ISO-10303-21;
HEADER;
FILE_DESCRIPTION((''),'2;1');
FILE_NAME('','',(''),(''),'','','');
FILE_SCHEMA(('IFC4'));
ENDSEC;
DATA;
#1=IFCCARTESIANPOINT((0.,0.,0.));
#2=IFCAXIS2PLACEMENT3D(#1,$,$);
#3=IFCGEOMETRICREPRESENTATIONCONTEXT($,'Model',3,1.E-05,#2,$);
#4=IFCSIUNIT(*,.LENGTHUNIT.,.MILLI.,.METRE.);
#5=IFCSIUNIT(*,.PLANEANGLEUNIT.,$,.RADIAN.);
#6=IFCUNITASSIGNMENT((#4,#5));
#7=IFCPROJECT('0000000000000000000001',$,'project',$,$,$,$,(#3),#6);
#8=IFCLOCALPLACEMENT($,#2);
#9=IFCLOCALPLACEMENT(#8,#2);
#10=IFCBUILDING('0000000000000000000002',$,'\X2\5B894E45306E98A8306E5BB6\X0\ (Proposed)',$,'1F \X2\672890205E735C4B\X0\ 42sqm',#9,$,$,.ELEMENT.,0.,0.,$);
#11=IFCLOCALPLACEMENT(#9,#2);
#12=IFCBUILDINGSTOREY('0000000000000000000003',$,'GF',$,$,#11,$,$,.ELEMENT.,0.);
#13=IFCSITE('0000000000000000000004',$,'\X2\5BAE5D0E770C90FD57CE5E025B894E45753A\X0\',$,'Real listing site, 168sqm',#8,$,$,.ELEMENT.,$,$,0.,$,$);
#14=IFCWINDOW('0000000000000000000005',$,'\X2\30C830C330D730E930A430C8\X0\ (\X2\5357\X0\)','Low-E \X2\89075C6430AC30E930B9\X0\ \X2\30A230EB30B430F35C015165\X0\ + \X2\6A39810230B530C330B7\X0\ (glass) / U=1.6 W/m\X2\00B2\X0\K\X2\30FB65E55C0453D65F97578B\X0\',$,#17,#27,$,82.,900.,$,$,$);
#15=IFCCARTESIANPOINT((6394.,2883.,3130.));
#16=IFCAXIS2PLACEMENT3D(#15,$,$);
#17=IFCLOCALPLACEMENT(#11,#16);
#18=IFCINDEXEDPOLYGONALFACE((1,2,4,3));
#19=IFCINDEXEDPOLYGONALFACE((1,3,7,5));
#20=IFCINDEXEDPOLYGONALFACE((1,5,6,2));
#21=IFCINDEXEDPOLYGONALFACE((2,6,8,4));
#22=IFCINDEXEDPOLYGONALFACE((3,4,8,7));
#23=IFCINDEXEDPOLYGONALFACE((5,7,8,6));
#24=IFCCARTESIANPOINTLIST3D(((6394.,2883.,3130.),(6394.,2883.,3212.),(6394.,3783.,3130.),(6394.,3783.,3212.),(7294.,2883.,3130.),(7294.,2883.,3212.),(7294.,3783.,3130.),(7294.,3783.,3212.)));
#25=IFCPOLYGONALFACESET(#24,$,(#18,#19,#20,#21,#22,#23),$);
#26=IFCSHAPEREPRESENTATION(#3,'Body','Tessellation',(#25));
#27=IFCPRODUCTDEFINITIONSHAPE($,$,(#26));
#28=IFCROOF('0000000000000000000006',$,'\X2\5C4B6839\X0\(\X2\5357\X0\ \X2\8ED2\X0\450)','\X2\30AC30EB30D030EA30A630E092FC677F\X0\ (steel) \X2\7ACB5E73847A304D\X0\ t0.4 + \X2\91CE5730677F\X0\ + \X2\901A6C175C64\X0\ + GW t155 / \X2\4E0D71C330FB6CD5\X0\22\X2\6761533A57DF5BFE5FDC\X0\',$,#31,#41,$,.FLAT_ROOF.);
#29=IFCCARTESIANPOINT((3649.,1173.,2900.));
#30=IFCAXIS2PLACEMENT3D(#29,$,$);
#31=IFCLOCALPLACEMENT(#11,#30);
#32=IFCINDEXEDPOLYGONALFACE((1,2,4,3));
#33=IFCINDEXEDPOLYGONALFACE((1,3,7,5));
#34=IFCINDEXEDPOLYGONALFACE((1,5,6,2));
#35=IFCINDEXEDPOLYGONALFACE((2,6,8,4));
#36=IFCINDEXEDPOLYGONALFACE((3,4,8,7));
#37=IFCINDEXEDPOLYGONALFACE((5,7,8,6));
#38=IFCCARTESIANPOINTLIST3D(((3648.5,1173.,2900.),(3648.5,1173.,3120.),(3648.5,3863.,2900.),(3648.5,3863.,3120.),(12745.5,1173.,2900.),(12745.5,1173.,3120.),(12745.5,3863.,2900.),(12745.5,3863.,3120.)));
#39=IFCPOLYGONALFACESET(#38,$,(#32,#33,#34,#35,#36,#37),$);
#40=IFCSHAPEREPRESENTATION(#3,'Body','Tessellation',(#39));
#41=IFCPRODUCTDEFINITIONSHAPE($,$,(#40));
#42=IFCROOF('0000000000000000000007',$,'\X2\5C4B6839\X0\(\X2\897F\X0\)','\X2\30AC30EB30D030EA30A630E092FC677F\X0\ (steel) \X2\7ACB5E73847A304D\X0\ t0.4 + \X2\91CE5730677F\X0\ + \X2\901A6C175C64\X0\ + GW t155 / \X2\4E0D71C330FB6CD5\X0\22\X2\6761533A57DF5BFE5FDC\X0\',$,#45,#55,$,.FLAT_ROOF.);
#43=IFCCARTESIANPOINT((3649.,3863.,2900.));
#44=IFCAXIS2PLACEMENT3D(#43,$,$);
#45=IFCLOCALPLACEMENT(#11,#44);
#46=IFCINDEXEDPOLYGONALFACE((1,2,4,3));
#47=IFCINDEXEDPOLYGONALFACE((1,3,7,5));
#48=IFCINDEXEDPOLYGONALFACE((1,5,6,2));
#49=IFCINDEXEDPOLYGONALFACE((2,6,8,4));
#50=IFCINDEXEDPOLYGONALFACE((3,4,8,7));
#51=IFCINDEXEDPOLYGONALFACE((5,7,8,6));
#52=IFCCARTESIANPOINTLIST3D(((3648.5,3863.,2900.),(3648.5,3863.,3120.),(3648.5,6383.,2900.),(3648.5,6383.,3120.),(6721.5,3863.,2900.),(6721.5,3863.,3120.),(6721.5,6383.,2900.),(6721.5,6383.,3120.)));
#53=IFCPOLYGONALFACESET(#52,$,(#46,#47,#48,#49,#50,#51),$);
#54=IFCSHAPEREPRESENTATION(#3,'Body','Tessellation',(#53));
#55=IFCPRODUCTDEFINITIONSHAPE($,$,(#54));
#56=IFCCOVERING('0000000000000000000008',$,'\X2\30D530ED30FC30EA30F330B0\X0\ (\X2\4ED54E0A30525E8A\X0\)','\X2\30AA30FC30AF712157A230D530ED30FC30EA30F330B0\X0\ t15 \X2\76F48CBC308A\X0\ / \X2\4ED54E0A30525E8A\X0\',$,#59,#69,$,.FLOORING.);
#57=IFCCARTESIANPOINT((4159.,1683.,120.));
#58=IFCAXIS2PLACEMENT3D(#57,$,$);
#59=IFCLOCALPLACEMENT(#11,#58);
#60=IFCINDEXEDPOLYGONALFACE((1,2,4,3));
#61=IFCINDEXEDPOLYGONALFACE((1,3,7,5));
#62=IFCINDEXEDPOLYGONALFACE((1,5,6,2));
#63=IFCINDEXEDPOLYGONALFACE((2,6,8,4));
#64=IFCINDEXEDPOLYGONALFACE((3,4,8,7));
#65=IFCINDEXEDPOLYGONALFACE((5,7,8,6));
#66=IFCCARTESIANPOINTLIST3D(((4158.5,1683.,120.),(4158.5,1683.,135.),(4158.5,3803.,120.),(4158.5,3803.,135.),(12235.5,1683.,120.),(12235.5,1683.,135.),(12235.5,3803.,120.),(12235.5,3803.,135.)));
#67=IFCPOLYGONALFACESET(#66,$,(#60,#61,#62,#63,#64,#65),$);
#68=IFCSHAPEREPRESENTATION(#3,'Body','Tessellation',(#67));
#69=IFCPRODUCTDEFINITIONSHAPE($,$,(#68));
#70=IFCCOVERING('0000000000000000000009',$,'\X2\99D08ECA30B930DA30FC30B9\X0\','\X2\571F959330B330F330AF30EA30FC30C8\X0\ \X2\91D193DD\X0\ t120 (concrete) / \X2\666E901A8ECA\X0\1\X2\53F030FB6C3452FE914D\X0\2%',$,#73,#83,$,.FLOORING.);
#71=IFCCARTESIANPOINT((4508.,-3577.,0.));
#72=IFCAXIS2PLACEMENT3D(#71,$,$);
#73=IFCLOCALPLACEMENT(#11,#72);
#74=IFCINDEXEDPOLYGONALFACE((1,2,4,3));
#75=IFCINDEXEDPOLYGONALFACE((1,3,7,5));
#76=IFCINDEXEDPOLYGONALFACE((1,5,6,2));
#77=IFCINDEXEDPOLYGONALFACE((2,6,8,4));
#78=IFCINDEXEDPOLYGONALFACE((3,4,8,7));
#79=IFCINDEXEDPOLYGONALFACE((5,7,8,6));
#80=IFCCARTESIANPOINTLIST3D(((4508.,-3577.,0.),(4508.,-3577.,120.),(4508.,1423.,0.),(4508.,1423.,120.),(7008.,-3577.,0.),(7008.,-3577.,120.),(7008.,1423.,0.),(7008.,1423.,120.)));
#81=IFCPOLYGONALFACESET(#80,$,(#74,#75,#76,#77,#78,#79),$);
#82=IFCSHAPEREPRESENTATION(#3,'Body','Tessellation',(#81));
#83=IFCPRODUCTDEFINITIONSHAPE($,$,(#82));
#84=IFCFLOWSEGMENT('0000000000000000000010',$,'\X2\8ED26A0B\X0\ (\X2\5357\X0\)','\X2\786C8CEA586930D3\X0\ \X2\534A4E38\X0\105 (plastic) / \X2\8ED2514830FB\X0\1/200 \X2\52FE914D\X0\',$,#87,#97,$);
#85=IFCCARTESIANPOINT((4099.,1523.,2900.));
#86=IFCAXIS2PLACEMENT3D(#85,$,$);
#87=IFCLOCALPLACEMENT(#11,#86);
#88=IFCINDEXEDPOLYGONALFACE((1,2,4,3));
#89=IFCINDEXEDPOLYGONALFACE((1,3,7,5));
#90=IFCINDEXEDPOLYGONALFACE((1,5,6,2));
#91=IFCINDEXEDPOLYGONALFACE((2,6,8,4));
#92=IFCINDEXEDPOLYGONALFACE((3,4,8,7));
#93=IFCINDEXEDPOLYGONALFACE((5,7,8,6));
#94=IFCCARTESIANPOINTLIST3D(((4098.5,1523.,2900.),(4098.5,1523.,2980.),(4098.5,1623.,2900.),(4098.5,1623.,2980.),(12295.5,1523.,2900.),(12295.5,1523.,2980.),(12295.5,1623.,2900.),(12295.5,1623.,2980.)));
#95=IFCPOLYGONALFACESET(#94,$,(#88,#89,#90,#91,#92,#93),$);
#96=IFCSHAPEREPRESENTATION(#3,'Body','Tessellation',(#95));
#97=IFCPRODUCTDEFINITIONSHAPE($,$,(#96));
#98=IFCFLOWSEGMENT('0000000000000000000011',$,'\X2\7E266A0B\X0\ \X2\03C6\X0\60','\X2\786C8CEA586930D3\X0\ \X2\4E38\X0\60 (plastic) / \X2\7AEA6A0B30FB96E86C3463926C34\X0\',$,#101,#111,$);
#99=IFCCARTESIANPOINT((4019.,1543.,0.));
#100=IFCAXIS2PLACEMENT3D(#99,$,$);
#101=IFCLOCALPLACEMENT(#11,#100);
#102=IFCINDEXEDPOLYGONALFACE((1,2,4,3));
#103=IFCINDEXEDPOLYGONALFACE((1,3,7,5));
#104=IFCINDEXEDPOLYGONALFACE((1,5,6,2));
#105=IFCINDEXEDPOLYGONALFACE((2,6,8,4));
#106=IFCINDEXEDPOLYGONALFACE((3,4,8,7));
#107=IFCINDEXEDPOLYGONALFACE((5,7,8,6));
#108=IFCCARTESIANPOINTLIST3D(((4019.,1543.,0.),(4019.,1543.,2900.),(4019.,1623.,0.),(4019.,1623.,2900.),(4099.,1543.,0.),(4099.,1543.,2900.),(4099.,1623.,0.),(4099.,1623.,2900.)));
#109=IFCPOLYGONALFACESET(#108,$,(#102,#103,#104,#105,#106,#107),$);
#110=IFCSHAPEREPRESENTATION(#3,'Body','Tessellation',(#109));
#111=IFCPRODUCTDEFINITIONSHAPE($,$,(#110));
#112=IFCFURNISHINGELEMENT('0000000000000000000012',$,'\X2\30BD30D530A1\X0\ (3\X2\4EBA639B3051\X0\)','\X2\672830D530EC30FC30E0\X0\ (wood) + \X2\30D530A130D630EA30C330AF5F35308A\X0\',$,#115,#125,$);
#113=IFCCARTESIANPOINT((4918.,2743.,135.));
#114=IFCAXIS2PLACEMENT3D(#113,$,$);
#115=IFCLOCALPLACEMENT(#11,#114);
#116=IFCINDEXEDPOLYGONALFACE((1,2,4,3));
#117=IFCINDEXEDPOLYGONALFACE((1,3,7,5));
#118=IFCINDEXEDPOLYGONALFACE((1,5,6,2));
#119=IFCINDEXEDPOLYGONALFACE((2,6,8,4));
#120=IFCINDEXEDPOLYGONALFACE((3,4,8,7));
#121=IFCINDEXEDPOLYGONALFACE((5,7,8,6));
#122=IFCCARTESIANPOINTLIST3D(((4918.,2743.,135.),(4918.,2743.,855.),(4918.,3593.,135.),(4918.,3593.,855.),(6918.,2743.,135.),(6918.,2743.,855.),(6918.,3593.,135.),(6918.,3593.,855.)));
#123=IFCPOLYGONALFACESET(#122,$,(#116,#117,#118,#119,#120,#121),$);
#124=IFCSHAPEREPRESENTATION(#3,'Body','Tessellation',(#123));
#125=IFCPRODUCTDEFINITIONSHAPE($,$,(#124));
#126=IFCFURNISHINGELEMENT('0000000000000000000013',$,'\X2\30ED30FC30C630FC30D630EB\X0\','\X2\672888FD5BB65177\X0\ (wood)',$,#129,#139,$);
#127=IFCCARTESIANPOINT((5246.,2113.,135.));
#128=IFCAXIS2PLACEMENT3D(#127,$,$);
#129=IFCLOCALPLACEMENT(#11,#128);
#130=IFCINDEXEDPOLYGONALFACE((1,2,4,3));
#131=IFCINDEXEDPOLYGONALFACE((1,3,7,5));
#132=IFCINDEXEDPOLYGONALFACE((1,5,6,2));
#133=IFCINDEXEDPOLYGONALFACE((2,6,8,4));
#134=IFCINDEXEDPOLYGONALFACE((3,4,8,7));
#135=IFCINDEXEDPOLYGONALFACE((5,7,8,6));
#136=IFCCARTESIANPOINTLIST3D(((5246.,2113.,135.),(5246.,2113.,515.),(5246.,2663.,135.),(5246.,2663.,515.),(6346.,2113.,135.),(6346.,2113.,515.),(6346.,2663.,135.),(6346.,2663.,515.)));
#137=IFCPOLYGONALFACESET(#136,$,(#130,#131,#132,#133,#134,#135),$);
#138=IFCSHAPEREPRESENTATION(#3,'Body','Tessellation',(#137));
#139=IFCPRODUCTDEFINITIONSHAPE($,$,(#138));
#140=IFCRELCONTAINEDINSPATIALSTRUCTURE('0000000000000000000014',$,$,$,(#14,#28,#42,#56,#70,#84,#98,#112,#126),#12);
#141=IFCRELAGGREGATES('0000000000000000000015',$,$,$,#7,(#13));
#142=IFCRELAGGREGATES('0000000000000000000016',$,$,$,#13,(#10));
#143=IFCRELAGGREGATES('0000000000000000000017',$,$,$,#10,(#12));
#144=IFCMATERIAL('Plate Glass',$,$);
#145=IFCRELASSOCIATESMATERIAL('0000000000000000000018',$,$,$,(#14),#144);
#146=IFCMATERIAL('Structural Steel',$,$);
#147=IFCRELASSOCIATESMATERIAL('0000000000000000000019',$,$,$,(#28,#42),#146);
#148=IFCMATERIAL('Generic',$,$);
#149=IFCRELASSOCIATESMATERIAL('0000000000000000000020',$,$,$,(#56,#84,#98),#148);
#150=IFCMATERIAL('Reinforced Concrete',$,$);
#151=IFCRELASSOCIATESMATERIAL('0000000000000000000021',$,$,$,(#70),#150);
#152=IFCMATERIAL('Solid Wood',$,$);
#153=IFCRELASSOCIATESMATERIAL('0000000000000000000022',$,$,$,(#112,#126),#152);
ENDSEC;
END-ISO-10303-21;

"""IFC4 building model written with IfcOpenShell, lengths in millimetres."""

from ifc_helpers import new_model, si_unit, frame, frame_2d, origin, place, context, project, spatial, rectangle, extrude, material, element, save


model = new_model("IFC4")

# Units and contexts
model_context = context("Model", 3, precision=1e-05, world=origin())
ifc_project = project(units=[si_unit("LENGTHUNIT", "METRE", prefix="MILLI"), si_unit("PLANEANGLEUNIT", "RADIAN")], contexts=[model_context])

# Site, building, storey
site_placement = place(None, origin())
site = spatial("IfcSite", under=ifc_project, at=site_placement, Name="宮崎県都城市安久町", ObjectType="Real listing site, 168sqm", CompositionType="ELEMENT", RefElevation=0.0)
building_placement = place(site_placement, origin())
building = spatial("IfcBuilding", under=site, at=building_placement, Name="安久の風の家 (Proposed)", ObjectType="1F 木造平屋 42sqm", CompositionType="ELEMENT", ElevationOfRefHeight=0.0, ElevationOfTerrain=0.0)
storey_placement = place(building_placement, origin())
storey = spatial("IfcBuildingStorey", under=building, at=storey_placement, Name="GF", CompositionType="ELEMENT", Elevation=0.0)

# Shared definitions
ifc_material_1 = material(Name="Solid Wood")

# Shared definitions
ifc_material_2 = material(Name="Reinforced Concrete")

# Shared definitions
ifc_material_3 = material(Name="Plate Glass")

# Window
window_1_placement = place(storey_placement, frame((6394.0, 2883.0, 3130.0)))
element("IfcWindow", 1, at=window_1_placement, inside=storey, material=ifc_material_3, Name="トップライト (南)", Description="Low-E 複層ガラス アルゴン封入 + 樹脂サッシ (glass) / U=1.6 W/m²K・日射取得型", OverallHeight=82.0, OverallWidth=900.0, context=model_context, shape_type="SweptSolid", body=[
    extrude(rectangle(XDim=900.0, YDim=900.0, at=frame_2d((450.0, 450.0))), frame((6394.0, 2883.0, 3130.0)), (0.0, 0.0, 1.0), 82.0),
])

# Roofs
ifc_material_4 = material(Name="Structural Steel")
roof_1_placement = place(storey_placement, frame((3649.0, 1173.0, 2900.0)))
element("IfcRoof", 2, at=roof_1_placement, inside=storey, material=ifc_material_4, Name="屋根(南 軒450)", Description="ガルバリウム鋼板 (steel) 立平葺き t0.4 + 野地板 + 通気層 + GW t155 / 不燃・法22条区域対応", PredefinedType="FLAT_ROOF", context=model_context, shape_type="SweptSolid", body=[
    extrude(rectangle(XDim=9097.0, YDim=2690.0, at=frame_2d((4548.0, 1345.0))), frame((3649.0, 1173.0, 2900.0)), (0.0, 0.0, 1.0), 220.0),
])
roof_2_placement = place(storey_placement, frame((3649.0, 3863.0, 2900.0)))
element("IfcRoof", 3, at=roof_2_placement, inside=storey, material=ifc_material_4, Name="屋根(西)", Description="ガルバリウム鋼板 (steel) 立平葺き t0.4 + 野地板 + 通気層 + GW t155 / 不燃・法22条区域対応", PredefinedType="FLAT_ROOF", context=model_context, shape_type="SweptSolid", body=[
    extrude(rectangle(XDim=3073.0, YDim=2520.0, at=frame_2d((1536.0, 1260.0))), frame((3649.0, 3863.0, 2900.0)), (0.0, 0.0, 1.0), 220.0),
])

# Coverings
ifc_material_5 = material(Name="Generic")
covering_1_placement = place(storey_placement, frame((4159.0, 1683.0, 120.0)))
element("IfcCovering", 4, at=covering_1_placement, inside=storey, material=ifc_material_5, Name="フローリング (仕上げ床)", Description="オーク無垢フローリング t15 直貼り / 仕上げ床", PredefinedType="FLOORING", context=model_context, shape_type="SweptSolid", body=[
    extrude(rectangle(XDim=8077.0, YDim=2120.0, at=frame_2d((4038.0, 1060.0))), frame((4159.0, 1683.0, 120.0)), (0.0, 0.0, 1.0), 15.0),
])
covering_2_placement = place(storey_placement, frame((4508.0, -3577.0, 0.0)))
element("IfcCovering", 5, at=covering_2_placement, inside=storey, material=ifc_material_2, Name="駐車スペース", Description="土間コンクリート 金鏝 t120 (concrete) / 普通車1台・水勾配2%", PredefinedType="FLOORING", context=model_context, shape_type="SweptSolid", body=[
    extrude(rectangle(XDim=2500.0, YDim=5000.0, at=frame_2d((1250.0, 2500.0))), frame((4508.0, -3577.0, 0.0)), (0.0, 0.0, 1.0), 120.0),
])

# Flow segments
flow_segment_1_placement = place(storey_placement, frame((4099.0, 1523.0, 2900.0)))
element("IfcFlowSegment", 6, at=flow_segment_1_placement, inside=storey, material=ifc_material_5, Name="軒樋 (南)", Description="硬質塩ビ 半丸105 (plastic) / 軒先・1/200 勾配", context=model_context, shape_type="SweptSolid", body=[
    extrude(rectangle(XDim=8197.0, YDim=100.0, at=frame_2d((4098.0, 50.0))), frame((4099.0, 1523.0, 2900.0)), (0.0, 0.0, 1.0), 80.0),
])
flow_segment_2_placement = place(storey_placement, frame((4019.0, 1543.0, 0.0)))
element("IfcFlowSegment", 7, at=flow_segment_2_placement, inside=storey, material=ifc_material_5, Name="縦樋 φ60", Description="硬質塩ビ 丸60 (plastic) / 竪樋・雨水排水", context=model_context, shape_type="SweptSolid", body=[
    extrude(rectangle(XDim=80.0, YDim=80.0, at=frame_2d((40.0, 40.0))), frame((4019.0, 1543.0, 0.0)), (0.0, 0.0, 1.0), 2900.0),
])

# Furnishing elements
furnishing_1_placement = place(storey_placement, frame((4918.0, 2743.0, 135.0)))
element("IfcFurnishingElement", 8, at=furnishing_1_placement, inside=storey, material=ifc_material_1, Name="ソファ (3人掛け)", Description="木フレーム (wood) + ファブリック張り", context=model_context, shape_type="SweptSolid", body=[
    extrude(rectangle(XDim=2000.0, YDim=850.0, at=frame_2d((1000.0, 425.0))), frame((4918.0, 2743.0, 135.0)), (0.0, 0.0, 1.0), 720.0),
])
furnishing_2_placement = place(storey_placement, frame((5246.0, 2113.0, 135.0)))
element("IfcFurnishingElement", 9, at=furnishing_2_placement, inside=storey, material=ifc_material_1, Name="ローテーブル", Description="木製家具 (wood)", context=model_context, shape_type="SweptSolid", body=[
    extrude(rectangle(XDim=1100.0, YDim=550.0, at=frame_2d((550.0, 275.0))), frame((5246.0, 2113.0, 135.0)), (0.0, 0.0, 1.0), 380.0),
])

save(model, "model.ifc")
